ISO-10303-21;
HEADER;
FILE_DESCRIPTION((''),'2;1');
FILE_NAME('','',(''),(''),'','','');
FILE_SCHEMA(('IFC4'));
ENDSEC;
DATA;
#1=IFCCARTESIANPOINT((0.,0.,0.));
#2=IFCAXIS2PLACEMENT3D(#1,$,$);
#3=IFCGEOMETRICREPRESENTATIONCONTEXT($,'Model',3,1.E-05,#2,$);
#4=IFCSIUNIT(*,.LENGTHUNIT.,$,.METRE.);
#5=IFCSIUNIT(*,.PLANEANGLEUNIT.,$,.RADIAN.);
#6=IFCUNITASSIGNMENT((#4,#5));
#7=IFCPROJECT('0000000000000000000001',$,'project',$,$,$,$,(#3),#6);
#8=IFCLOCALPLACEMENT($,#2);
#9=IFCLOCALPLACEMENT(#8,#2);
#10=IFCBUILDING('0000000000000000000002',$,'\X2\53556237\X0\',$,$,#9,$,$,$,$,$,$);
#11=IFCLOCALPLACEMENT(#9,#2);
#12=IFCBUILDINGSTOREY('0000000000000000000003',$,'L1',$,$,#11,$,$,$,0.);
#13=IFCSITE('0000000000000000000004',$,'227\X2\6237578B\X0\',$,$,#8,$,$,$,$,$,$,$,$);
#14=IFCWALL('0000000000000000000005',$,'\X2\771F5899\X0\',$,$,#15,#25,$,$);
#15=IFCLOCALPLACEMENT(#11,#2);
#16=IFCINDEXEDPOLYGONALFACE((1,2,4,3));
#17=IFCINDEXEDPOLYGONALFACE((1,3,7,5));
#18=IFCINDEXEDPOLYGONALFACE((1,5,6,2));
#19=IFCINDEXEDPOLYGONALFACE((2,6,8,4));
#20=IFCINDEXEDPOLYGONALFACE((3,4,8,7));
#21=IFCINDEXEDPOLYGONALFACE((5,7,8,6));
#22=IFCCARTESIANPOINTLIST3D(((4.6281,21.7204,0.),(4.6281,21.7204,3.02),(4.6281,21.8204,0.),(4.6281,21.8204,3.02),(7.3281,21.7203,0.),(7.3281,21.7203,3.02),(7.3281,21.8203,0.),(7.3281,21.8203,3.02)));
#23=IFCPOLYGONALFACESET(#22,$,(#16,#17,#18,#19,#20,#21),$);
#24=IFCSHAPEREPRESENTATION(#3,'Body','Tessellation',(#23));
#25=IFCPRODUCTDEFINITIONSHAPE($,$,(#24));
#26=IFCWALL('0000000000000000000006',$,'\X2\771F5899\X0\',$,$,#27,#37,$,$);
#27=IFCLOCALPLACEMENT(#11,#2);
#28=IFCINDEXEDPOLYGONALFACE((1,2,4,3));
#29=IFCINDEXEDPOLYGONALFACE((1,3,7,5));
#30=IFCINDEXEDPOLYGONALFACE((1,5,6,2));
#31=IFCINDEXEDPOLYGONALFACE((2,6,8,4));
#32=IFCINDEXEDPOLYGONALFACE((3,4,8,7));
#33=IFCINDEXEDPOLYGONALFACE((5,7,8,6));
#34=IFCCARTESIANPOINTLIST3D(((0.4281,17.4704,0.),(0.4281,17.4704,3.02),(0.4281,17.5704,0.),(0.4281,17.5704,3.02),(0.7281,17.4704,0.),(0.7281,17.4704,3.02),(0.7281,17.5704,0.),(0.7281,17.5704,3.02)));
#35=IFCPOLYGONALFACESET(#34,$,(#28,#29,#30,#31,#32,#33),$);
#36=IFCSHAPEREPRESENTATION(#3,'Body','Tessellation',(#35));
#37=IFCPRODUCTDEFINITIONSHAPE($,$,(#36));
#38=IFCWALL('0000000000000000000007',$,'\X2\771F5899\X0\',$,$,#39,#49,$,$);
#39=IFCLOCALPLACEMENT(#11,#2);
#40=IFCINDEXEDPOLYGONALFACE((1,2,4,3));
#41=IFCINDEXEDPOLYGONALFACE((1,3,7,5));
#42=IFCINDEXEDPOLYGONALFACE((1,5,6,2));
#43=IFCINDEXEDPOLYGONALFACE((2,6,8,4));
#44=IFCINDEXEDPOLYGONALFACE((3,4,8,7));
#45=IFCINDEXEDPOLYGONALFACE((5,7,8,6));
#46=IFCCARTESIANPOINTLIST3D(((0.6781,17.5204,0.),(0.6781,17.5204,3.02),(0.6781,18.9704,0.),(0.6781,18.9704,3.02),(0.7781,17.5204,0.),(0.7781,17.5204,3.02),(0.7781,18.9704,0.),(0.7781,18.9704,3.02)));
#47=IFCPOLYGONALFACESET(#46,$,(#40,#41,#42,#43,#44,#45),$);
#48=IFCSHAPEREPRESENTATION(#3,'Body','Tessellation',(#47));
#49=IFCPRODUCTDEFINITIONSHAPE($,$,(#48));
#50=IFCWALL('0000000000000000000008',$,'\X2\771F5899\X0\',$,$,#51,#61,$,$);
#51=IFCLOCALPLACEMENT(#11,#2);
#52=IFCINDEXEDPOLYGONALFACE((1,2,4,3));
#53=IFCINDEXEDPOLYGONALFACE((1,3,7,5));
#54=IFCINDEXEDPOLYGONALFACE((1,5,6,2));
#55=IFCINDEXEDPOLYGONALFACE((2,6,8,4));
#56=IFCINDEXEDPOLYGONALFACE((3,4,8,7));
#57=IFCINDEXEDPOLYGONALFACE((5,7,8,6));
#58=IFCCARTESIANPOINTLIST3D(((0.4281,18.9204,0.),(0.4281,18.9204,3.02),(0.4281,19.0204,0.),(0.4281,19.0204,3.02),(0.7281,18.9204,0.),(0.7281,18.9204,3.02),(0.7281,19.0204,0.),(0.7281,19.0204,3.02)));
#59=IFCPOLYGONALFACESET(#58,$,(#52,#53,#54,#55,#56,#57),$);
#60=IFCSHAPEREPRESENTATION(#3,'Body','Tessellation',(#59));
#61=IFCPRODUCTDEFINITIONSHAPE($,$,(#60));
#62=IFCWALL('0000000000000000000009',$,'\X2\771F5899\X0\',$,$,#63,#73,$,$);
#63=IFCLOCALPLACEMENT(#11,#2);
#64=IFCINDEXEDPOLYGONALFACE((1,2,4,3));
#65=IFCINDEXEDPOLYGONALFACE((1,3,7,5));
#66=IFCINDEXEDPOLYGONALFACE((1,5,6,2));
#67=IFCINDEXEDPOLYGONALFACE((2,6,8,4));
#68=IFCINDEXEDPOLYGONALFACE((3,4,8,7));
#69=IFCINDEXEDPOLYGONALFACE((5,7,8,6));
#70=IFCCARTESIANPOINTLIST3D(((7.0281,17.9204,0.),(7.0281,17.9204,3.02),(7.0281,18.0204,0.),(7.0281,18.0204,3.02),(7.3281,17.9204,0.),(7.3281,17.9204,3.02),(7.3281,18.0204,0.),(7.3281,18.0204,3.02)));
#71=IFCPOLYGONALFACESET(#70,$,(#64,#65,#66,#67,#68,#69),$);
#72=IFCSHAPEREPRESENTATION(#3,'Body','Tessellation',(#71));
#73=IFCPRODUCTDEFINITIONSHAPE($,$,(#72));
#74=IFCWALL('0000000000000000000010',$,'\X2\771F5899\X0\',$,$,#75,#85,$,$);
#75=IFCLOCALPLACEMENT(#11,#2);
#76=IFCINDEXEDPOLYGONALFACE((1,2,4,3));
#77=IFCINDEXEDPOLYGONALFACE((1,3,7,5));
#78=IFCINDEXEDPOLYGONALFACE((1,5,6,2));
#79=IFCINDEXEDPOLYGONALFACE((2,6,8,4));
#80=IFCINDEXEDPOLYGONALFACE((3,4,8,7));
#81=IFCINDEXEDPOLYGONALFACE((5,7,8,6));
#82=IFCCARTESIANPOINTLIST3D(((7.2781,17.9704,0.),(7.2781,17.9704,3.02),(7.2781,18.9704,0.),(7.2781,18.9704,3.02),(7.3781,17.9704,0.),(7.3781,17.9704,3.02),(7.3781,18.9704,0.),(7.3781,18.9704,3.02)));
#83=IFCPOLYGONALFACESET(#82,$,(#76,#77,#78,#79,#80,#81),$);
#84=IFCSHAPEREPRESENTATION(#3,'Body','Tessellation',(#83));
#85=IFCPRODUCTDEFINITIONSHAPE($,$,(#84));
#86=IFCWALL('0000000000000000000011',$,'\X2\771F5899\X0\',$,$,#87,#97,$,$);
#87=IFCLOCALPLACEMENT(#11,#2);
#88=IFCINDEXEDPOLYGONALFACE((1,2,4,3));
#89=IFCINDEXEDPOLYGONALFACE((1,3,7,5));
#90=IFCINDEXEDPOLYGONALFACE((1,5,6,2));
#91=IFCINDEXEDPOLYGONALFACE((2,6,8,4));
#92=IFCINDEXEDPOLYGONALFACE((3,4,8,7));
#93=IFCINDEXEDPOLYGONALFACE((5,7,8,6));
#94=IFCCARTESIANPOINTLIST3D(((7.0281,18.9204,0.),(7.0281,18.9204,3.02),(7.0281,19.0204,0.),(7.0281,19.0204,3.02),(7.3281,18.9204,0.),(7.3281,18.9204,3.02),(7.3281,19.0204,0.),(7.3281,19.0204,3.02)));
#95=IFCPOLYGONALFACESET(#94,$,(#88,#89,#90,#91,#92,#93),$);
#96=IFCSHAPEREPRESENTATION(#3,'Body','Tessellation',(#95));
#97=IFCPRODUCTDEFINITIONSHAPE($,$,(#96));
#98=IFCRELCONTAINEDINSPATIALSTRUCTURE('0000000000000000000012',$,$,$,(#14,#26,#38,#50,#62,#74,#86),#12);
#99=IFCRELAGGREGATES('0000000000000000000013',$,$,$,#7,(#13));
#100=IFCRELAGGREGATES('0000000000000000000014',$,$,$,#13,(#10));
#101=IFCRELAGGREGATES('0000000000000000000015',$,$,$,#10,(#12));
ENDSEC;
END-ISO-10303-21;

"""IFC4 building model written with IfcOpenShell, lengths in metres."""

from ifc_helpers import new_model, si_unit, origin, place, context, project, spatial, polyline, outline, extrude, element, save


model = new_model("IFC4")

# Units and contexts
model_context = context("Model", 3, precision=1e-05, world=origin())
ifc_project = project(units=[si_unit("LENGTHUNIT", "METRE"), si_unit("PLANEANGLEUNIT", "RADIAN")], contexts=[model_context])

# Site, building, storey
site_placement = place(None, origin())
site = spatial("IfcSite", under=ifc_project, at=site_placement, Name="227户型")
building_placement = place(site_placement, origin())
building = spatial("IfcBuilding", under=site, at=building_placement, Name="单户")
storey_placement = place(building_placement, origin())
storey = spatial("IfcBuildingStorey", under=building, at=storey_placement, Name="L1", Elevation=0.0)

# Wall
wall_1_placement = place(storey_placement, origin())
element("IfcWall", 1, at=wall_1_placement, inside=storey, Name="真墙", context=model_context, shape_type="SweptSolid", body=[
    extrude(outline(polyline([(4.6281, 21.8204), (7.3281, 21.8203), (7.3281, 21.7203), (4.6281, 21.7204), (4.6281, 21.8204)])), origin(), (0.0, 0.0, 1.0), 3.02),
])

# Walls
wall_2_placement = place(storey_placement, origin())
element("IfcWall", 2, at=wall_2_placement, inside=storey, Name="真墙", context=model_context, shape_type="SweptSolid", body=[
    extrude(outline(polyline([(0.4281, 17.5704), (0.7281, 17.5704), (0.7281, 17.4704), (0.4281, 17.4704), (0.4281, 17.5704)])), origin(), (0.0, 0.0, 1.0), 3.02),
])
wall_3_placement = place(storey_placement, origin())
element("IfcWall", 3, at=wall_3_placement, inside=storey, Name="真墙", context=model_context, shape_type="SweptSolid", body=[
    extrude(outline(polyline([(0.6781, 17.5204), (0.6781, 18.9704), (0.7781, 18.9704), (0.7781, 17.5204), (0.6781, 17.5204)])), origin(), (0.0, 0.0, 1.0), 3.02),
])
wall_4_placement = place(storey_placement, origin())
element("IfcWall", 4, at=wall_4_placement, inside=storey, Name="真墙", context=model_context, shape_type="SweptSolid", body=[
    extrude(outline(polyline([(0.7281, 18.9204), (0.4281, 18.9204), (0.4281, 19.0204), (0.7281, 19.0204), (0.7281, 18.9204)])), origin(), (0.0, 0.0, 1.0), 3.02),
])
wall_5_placement = place(storey_placement, origin())
element("IfcWall", 5, at=wall_5_placement, inside=storey, Name="真墙", context=model_context, shape_type="SweptSolid", body=[
    extrude(outline(polyline([(7.0281, 18.0204), (7.3281, 18.0204), (7.3281, 17.9204), (7.0281, 17.9204), (7.0281, 18.0204)])), origin(), (0.0, 0.0, 1.0), 3.02),
])
wall_6_placement = place(storey_placement, origin())
element("IfcWall", 6, at=wall_6_placement, inside=storey, Name="真墙", context=model_context, shape_type="SweptSolid", body=[
    extrude(outline(polyline([(7.2781, 17.9704), (7.2781, 18.9704), (7.3781, 18.9704), (7.3781, 17.9704), (7.2781, 17.9704)])), origin(), (0.0, 0.0, 1.0), 3.02),
])
wall_7_placement = place(storey_placement, origin())
element("IfcWall", 7, at=wall_7_placement, inside=storey, Name="真墙", context=model_context, shape_type="SweptSolid", body=[
    extrude(outline(polyline([(7.3281, 18.9204), (7.0281, 18.9204), (7.0281, 19.0204), (7.3281, 19.0204), (7.3281, 18.9204)])), origin(), (0.0, 0.0, 1.0), 3.02),
])

save(model, "model.ifc")
